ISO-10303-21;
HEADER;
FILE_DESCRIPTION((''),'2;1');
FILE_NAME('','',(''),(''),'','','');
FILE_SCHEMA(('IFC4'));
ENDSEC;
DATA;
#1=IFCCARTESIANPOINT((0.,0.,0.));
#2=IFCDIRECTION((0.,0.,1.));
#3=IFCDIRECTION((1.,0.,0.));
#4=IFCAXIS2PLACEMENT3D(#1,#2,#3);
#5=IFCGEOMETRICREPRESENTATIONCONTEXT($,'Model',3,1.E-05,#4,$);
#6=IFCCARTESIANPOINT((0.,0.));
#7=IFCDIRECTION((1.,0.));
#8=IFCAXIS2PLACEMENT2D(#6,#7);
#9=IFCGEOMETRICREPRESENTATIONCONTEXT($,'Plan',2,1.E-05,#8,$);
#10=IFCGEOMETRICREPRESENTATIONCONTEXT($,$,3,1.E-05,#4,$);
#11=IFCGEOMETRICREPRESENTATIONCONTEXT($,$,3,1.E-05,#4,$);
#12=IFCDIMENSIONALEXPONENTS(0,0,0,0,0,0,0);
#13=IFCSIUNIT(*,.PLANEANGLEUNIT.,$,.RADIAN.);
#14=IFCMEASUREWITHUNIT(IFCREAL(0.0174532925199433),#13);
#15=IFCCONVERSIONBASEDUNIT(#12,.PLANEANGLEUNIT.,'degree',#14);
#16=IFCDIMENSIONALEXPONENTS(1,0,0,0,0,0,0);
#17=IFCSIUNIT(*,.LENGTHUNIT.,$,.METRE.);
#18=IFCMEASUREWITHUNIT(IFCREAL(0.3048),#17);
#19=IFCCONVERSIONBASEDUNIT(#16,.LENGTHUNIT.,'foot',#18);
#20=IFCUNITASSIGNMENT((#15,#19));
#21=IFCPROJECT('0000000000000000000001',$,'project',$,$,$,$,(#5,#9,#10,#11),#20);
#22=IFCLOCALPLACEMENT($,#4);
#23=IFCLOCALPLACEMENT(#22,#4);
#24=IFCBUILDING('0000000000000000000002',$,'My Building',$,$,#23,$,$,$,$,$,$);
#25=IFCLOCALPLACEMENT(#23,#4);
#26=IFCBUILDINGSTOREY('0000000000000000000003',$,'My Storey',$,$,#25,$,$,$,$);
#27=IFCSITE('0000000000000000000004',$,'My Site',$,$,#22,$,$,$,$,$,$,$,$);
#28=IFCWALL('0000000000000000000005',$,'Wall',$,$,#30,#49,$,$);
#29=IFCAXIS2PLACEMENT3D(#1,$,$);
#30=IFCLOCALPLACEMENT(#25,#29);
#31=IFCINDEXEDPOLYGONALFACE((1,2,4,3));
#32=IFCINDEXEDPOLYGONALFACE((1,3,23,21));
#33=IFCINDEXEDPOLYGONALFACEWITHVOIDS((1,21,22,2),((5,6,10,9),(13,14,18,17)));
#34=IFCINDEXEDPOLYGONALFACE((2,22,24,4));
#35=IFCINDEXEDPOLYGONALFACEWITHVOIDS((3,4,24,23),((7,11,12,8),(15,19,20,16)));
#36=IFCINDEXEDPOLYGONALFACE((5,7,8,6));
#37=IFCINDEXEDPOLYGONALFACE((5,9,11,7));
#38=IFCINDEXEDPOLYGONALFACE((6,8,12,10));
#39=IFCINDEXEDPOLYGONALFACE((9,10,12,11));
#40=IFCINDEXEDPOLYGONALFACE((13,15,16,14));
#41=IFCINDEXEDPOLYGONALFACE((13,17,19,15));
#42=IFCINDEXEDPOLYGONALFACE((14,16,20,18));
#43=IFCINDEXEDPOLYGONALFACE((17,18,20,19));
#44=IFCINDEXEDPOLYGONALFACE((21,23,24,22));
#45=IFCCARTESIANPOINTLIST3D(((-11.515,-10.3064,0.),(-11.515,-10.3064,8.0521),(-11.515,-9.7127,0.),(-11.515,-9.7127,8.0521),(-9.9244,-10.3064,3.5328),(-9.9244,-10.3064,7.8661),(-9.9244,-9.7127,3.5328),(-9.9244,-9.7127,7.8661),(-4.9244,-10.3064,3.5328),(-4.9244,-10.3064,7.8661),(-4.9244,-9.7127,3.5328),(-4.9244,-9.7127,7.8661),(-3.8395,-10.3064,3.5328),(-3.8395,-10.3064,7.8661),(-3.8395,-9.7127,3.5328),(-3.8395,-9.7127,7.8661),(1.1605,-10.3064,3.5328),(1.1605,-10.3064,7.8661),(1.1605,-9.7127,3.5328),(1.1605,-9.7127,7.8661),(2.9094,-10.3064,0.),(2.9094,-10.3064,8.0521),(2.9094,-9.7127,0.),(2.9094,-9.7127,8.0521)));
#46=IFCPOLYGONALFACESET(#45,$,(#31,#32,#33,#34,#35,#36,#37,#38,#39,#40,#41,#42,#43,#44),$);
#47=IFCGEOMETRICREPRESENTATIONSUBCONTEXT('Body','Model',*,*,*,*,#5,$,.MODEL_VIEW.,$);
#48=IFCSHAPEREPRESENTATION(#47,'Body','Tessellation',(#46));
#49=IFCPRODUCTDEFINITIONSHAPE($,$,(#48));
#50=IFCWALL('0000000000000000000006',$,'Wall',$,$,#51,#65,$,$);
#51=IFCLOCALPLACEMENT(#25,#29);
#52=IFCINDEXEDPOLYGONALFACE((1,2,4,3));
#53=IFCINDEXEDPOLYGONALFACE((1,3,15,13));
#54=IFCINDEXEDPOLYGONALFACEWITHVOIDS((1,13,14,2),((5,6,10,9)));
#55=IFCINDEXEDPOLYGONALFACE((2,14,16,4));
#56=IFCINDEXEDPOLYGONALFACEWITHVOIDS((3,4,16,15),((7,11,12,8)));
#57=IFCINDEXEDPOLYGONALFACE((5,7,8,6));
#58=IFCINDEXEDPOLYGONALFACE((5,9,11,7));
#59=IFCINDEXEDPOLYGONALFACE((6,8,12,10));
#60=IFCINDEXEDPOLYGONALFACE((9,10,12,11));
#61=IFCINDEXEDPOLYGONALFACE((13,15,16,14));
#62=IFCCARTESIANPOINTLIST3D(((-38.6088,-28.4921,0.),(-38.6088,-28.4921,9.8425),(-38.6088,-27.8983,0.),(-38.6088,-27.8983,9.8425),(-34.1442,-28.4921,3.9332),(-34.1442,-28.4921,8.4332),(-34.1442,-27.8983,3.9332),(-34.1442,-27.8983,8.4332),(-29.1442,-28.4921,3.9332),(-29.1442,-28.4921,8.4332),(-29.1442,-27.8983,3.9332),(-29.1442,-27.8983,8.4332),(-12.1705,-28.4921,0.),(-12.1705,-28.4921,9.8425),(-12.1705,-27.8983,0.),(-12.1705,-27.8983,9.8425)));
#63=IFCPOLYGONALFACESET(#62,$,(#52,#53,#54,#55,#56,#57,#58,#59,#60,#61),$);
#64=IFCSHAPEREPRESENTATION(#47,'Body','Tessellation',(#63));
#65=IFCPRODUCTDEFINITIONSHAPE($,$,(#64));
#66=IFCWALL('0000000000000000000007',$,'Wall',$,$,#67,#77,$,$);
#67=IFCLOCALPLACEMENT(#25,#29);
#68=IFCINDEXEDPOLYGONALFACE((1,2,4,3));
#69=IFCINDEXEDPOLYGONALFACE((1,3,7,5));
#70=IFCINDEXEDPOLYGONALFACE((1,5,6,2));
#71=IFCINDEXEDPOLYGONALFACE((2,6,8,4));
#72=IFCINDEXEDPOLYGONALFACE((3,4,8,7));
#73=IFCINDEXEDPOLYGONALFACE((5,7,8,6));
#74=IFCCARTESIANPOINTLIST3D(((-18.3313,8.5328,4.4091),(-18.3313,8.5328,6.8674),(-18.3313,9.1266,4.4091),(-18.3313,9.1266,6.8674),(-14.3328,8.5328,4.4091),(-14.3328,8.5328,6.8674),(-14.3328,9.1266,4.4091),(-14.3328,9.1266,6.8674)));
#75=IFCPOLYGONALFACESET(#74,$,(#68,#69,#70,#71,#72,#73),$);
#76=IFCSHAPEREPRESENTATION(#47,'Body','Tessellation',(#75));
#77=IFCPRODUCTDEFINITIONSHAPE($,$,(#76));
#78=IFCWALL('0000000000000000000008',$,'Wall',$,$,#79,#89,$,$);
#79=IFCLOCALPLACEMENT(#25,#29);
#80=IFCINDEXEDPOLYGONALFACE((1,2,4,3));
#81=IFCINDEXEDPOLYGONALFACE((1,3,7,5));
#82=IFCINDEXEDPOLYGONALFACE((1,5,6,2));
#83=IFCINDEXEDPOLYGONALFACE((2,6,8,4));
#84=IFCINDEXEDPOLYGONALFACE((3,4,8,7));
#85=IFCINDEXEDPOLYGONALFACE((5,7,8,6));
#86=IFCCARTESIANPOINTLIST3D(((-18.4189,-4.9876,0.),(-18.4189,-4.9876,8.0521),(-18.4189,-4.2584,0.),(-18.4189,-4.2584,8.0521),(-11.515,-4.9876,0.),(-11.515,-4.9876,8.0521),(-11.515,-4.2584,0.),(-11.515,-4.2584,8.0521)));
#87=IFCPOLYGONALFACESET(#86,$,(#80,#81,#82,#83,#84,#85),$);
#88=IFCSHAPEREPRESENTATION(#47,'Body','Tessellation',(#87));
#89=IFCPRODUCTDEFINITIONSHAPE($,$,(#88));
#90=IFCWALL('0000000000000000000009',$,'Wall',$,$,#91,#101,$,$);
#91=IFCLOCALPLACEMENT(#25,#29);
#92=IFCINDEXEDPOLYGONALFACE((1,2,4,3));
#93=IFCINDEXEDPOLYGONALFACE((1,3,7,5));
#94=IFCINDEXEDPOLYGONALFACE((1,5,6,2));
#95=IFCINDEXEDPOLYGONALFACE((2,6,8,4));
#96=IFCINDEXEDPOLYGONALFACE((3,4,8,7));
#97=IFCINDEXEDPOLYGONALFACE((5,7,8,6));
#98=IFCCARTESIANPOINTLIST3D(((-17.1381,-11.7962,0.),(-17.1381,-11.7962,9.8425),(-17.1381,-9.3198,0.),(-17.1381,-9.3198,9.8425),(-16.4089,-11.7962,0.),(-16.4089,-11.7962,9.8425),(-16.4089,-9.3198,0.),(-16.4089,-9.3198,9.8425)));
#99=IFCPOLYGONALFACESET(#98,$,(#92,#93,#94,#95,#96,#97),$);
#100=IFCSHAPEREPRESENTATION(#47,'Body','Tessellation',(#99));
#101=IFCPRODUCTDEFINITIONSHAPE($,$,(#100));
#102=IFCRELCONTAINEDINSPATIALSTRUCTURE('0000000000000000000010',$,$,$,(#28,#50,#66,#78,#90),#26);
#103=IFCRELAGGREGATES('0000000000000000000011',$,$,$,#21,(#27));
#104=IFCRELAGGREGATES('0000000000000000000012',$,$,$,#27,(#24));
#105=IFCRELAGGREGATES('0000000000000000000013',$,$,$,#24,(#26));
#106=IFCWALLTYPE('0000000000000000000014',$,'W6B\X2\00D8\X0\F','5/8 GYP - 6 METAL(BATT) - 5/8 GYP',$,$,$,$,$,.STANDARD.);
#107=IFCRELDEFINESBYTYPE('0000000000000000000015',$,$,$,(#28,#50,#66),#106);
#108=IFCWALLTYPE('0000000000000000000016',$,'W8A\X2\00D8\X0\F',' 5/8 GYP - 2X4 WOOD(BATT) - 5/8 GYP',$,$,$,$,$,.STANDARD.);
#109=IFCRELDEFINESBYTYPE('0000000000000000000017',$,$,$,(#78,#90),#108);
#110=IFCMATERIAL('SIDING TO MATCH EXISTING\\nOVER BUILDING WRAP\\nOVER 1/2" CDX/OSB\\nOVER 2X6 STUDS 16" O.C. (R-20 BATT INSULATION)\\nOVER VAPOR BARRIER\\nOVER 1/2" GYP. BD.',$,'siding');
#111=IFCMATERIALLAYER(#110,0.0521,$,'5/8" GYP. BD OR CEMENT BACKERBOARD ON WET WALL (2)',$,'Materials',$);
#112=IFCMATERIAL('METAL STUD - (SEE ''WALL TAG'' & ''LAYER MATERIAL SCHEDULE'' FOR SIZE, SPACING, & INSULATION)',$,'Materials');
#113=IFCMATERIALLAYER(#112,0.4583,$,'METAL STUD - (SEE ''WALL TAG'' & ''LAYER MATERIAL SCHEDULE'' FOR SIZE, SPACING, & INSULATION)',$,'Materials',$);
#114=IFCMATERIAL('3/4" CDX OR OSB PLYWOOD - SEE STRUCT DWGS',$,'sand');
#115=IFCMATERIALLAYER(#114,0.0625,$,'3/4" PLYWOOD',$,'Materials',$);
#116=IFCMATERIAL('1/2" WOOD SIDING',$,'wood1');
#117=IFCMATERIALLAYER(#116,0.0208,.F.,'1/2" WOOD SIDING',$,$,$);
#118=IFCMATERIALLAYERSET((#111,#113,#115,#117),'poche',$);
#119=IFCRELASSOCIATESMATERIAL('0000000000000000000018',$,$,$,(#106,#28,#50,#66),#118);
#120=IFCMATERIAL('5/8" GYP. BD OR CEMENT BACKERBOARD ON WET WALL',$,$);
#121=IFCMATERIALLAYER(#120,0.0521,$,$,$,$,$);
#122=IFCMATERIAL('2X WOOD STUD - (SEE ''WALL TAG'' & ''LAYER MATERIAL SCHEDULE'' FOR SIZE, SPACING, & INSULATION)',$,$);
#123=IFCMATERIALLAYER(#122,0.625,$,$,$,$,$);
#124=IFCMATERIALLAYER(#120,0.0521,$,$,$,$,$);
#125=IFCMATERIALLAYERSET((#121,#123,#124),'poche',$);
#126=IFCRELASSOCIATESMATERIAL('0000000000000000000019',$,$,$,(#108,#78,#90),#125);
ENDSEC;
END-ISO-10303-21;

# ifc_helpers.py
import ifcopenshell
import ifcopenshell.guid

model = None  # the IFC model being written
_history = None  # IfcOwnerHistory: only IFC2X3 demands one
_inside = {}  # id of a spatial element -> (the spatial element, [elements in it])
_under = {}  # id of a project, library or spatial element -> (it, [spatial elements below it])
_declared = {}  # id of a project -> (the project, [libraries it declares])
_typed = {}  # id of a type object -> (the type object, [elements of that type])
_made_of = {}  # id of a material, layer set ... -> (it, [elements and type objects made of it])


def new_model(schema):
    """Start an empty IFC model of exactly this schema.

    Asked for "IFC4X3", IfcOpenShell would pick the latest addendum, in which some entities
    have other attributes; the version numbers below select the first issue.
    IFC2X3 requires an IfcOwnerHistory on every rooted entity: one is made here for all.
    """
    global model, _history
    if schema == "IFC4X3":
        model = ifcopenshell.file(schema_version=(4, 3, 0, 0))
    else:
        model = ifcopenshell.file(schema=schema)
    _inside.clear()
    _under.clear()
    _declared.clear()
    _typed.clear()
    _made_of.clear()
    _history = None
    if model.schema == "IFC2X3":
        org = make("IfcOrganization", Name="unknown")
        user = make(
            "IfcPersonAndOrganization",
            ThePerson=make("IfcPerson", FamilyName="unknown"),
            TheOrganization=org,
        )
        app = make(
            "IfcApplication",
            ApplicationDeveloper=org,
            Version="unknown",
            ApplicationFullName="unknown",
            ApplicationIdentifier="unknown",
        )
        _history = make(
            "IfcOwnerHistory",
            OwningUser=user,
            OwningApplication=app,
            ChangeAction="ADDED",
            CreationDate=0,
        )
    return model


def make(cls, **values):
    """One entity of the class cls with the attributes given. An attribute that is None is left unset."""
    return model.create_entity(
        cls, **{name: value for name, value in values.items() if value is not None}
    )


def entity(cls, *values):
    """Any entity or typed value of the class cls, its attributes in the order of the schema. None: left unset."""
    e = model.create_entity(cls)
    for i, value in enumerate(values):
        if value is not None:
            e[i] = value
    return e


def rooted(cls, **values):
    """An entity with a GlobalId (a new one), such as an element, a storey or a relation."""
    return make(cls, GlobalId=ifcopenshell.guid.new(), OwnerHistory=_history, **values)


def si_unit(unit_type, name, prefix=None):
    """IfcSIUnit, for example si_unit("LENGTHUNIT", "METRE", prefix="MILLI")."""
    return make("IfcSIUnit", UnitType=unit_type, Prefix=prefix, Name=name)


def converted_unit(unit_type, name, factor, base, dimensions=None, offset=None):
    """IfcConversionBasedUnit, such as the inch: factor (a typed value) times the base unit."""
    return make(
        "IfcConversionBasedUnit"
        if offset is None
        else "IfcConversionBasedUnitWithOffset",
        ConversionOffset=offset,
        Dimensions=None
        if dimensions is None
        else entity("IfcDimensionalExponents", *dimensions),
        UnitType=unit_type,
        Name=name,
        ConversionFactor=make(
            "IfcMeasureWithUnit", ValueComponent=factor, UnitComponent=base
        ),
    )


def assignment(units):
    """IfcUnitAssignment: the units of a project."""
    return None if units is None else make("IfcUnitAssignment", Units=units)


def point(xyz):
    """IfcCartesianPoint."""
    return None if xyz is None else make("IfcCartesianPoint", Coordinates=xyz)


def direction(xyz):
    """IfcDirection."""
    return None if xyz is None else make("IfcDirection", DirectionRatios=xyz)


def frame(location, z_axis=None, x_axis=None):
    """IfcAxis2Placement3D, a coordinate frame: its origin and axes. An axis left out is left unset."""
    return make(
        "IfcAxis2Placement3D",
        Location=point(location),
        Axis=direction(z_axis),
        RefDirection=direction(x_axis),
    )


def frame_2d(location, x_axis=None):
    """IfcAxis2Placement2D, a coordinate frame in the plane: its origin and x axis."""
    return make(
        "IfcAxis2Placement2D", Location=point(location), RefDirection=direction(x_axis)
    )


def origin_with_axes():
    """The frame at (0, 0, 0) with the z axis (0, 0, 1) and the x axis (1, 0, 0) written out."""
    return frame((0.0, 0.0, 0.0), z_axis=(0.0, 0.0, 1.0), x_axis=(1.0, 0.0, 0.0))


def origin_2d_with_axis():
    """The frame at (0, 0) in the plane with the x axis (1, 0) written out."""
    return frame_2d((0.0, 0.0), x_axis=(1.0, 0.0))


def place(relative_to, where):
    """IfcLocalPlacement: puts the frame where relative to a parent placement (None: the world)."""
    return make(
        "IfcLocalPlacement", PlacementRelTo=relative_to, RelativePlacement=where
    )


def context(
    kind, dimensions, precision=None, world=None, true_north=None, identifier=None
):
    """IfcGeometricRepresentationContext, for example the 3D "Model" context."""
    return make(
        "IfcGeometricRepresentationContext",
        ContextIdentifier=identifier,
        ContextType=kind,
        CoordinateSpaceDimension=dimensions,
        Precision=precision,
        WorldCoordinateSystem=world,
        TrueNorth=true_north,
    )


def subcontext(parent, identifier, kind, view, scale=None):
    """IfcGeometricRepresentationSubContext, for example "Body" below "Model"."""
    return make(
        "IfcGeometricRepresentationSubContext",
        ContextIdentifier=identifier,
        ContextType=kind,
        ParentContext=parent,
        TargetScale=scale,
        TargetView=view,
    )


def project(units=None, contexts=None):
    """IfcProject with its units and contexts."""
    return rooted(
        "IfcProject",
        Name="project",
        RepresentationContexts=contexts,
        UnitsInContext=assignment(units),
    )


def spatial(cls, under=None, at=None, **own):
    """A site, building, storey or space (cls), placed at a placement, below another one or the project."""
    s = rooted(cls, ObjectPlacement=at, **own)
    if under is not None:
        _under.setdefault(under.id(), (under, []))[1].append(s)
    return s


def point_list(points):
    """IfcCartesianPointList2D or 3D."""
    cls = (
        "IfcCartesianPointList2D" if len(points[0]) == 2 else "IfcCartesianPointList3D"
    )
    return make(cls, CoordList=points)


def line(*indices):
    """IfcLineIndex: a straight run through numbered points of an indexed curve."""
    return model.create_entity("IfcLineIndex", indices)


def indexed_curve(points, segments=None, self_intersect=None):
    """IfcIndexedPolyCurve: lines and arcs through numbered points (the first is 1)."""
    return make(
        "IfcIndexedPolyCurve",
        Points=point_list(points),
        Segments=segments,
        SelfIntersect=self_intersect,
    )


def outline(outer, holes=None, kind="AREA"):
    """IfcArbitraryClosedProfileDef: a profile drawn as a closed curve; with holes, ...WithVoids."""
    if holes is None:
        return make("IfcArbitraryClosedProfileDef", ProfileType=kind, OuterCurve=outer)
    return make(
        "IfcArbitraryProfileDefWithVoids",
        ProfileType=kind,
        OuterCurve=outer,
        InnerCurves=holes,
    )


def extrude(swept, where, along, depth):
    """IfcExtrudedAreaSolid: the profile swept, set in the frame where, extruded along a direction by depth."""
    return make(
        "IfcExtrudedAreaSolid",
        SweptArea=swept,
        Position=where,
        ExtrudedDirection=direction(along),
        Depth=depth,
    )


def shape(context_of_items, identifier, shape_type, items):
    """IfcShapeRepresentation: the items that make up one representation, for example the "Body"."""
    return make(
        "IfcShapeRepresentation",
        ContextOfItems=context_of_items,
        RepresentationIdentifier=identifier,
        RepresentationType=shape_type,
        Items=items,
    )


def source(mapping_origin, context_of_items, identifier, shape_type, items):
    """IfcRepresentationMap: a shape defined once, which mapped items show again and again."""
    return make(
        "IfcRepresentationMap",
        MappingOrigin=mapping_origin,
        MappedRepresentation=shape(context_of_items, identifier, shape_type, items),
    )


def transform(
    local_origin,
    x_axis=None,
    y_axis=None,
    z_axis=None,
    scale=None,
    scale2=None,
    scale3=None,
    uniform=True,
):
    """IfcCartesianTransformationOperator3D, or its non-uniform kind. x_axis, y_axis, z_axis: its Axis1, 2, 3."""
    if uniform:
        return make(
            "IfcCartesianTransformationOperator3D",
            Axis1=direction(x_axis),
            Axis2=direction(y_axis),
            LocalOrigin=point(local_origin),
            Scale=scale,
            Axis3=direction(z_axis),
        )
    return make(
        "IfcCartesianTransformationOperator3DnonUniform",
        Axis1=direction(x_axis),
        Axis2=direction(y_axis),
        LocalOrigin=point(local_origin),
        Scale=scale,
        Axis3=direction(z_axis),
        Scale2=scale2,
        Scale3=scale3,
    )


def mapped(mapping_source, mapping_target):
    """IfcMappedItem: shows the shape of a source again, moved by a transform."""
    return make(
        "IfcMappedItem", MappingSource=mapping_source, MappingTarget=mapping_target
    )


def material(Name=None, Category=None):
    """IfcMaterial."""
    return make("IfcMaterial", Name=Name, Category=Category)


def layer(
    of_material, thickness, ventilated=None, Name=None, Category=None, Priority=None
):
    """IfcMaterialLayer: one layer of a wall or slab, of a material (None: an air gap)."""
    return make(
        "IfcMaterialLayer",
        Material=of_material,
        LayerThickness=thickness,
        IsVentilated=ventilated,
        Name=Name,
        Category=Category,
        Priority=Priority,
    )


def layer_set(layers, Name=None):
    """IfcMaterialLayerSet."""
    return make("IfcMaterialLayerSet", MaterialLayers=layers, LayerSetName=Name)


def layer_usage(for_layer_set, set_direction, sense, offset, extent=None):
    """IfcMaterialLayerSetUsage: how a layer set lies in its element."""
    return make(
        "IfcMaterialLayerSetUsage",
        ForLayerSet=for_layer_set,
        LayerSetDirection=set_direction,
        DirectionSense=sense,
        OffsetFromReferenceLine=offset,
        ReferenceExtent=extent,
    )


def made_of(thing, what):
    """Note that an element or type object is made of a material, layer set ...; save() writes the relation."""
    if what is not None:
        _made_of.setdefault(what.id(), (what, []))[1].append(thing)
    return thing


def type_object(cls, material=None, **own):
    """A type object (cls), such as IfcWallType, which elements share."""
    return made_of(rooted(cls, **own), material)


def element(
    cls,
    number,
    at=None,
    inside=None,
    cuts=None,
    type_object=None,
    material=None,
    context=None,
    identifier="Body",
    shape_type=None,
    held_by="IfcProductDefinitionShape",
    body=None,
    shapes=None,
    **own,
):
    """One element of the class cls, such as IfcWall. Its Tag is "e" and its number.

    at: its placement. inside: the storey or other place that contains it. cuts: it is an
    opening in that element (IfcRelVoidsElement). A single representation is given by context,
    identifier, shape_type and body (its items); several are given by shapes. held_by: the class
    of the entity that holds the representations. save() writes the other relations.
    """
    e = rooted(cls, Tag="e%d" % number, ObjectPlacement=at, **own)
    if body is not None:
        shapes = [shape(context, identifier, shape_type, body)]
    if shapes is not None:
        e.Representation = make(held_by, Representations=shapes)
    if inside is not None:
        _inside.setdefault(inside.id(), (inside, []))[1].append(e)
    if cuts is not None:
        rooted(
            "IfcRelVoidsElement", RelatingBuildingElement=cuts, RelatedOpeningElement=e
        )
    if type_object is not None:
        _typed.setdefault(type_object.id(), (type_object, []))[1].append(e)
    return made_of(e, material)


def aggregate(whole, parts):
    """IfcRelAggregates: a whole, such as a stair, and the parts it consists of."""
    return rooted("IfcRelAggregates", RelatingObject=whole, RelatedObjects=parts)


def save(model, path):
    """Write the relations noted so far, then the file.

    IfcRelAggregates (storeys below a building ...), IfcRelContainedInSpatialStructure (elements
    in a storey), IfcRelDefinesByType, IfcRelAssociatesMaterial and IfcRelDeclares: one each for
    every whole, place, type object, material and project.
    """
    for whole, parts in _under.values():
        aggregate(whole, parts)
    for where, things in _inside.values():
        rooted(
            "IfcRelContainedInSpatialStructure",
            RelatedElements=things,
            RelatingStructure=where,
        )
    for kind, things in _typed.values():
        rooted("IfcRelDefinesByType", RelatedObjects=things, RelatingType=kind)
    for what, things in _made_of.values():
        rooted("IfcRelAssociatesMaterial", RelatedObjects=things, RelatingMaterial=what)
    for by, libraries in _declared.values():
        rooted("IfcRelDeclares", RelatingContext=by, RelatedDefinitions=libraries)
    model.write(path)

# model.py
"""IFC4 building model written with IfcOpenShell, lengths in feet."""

from ifc_helpers import new_model, entity, si_unit, converted_unit, frame, origin_with_axes, origin_2d_with_axis, place, context, subcontext, project, spatial, line, indexed_curve, outline, extrude, source, transform, mapped, material, layer, layer_set, layer_usage, type_object, element, save


model = new_model("IFC4")

# Units and contexts
model_context = context("Model", 3, precision=1e-05, world=origin_with_axes())
plan_context = context("Plan", 2, precision=1e-05, world=origin_2d_with_axis())
context_of_model_1 = context(None, 3, precision=1e-05, world=origin_with_axes())
context_of_model_2 = context(None, 3, precision=1e-05, world=origin_with_axes())
body_context = subcontext(model_context, "Body", "Model", "MODEL_VIEW")
ifc_project = project(units=[converted_unit("PLANEANGLEUNIT", "degree", entity("IfcReal", 0.0174532925199433), si_unit("PLANEANGLEUNIT", "RADIAN"), dimensions=[0, 0, 0, 0, 0, 0, 0]), converted_unit("LENGTHUNIT", "foot", entity("IfcReal", 0.3048), si_unit("LENGTHUNIT", "METRE"), dimensions=[1, 0, 0, 0, 0, 0, 0])], contexts=[model_context, plan_context, context_of_model_1, context_of_model_2])

# Site, building, storey
site_placement = place(None, origin_with_axes())
site = spatial("IfcSite", under=ifc_project, at=site_placement, Name="My Site")
building_placement = place(site_placement, origin_with_axes())
building = spatial("IfcBuilding", under=site, at=building_placement, Name="My Building")
storey_placement = place(building_placement, origin_with_axes())
storey = spatial("IfcBuildingStorey", under=building, at=storey_placement, Name="My Storey")

# Shared definitions
ifc_material_1 = material(Name="5/8\" GYP. BD OR CEMENT BACKERBOARD ON WET WALL")
ifc_material_2 = material(Name="2X WOOD STUD - (SEE 'WALL TAG' & 'LAYER MATERIAL SCHEDULE' FOR SIZE, SPACING, & INSULATION)")
ifc_material_3 = material(Name="SIDING TO MATCH EXISTING\\nOVER BUILDING WRAP\\nOVER 1/2\" CDX/OSB\\nOVER 2X6 STUDS 16\" O.C. (R-20 BATT INSULATION)\\nOVER VAPOR BARRIER\\nOVER 1/2\" GYP. BD.", Category="siding")
ifc_layer_1 = layer(ifc_material_3, 0.0521, Name="5/8\" GYP. BD OR CEMENT BACKERBOARD ON WET WALL (2)", Category="Materials")
ifc_material_4 = material(Name="METAL STUD - (SEE 'WALL TAG' & 'LAYER MATERIAL SCHEDULE' FOR SIZE, SPACING, & INSULATION)", Category="Materials")
ifc_layer_2 = layer(ifc_material_4, 0.4583, Name="METAL STUD - (SEE 'WALL TAG' & 'LAYER MATERIAL SCHEDULE' FOR SIZE, SPACING, & INSULATION)", Category="Materials")
ifc_material_5 = material(Name="3/4\" CDX OR OSB PLYWOOD - SEE STRUCT DWGS", Category="sand")
ifc_layer_3 = layer(ifc_material_5, 0.0625, Name="3/4\" PLYWOOD", Category="Materials")
ifc_material_6 = material(Name="1/2\" WOOD SIDING", Category="wood1")
ifc_layer_4 = layer(ifc_material_6, 0.0208, ventilated=False, Name="1/2\" WOOD SIDING")
ifc_layer_set_1 = layer_set([ifc_layer_1, ifc_layer_2, ifc_layer_3, ifc_layer_4], Name="poche")
wall_type_1 = type_object("IfcWallType", Name="W6BØF", Description="5/8 GYP - 6 METAL(BATT) - 5/8 GYP", PredefinedType="STANDARD", material=ifc_layer_set_1)

# Wall, openings
ifc_layer_usage_1 = layer_usage(ifc_layer_set_1, "AXIS2", "POSITIVE", 0.0)
wall_1_placement = place(storey_placement, frame((-11.515, -10.3064, 0.0), z_axis=(0.0, 0.0, 1.0), x_axis=(1.0, 0.0, 0.0)))
wall_1 = element("IfcWall", 1, at=wall_1_placement, inside=storey, type_object=wall_type_1, material=ifc_layer_usage_1, Name="Wall", context=body_context, shape_type="SweptSolid", body=[
    extrude(outline(indexed_curve([(0.0, 0.0), (0.0, 0.5937), (14.4243, 0.5937), (14.4243, 0.0), (0.0, 0.0)], self_intersect=False)), origin_with_axes(), (0.0, 0.0, 1.0), 8.0521),
])
shared_shape_1 = source(origin_with_axes(), body_context, "Body", "SweptSolid", [
    extrude(outline(indexed_curve([(0.0, 0.0), (5.0, 0.0), (5.0, 4.3333), (0.0, 4.3333)], segments=[line(1, 2, 3, 4, 1)])), frame((0.0, -1.9685, 0.0), z_axis=(0.0, -1.0, 0.0), x_axis=(1.0, 0.0, 0.0)), (0.0, 0.0, -1.0), 3.937),
])
opening_1_placement = place(wall_1_placement, frame((1.5905, 0.0, 3.5328), z_axis=(0.0, 0.0, 1.0), x_axis=(1.0, 0.0, 0.0)))
element("IfcOpeningElement", 2, at=opening_1_placement, cuts=wall_1, PredefinedType="OPENING", context=body_context, shape_type="MappedRepresentation", body=[
    mapped(shared_shape_1, transform((0.0, 0.0, 0.0), x_axis=(1.0, 0.0, 0.0), y_axis=(0.0, 1.0, 0.0), z_axis=(0.0, 0.0, 1.0), scale=1.0)),
])
opening_2_placement = place(wall_1_placement, frame((7.6755, 0.0, 3.5328), z_axis=(0.0, 0.0, 1.0), x_axis=(1.0, 0.0, 0.0)))
element("IfcOpeningElement", 3, at=opening_2_placement, cuts=wall_1, PredefinedType="OPENING", context=body_context, shape_type="MappedRepresentation", body=[
    mapped(shared_shape_1, transform((0.0, 0.0, 0.0), x_axis=(1.0, 0.0, 0.0), y_axis=(0.0, 1.0, 0.0), z_axis=(0.0, 0.0, 1.0), scale=1.0)),
])

# Wall, opening
ifc_layer_usage_2 = layer_usage(ifc_layer_set_1, "AXIS2", "POSITIVE", 0.0)
wall_2_placement = place(storey_placement, frame((-12.1705, -27.8983, 0.0), z_axis=(0.0, 0.0, 1.0), x_axis=(-1.0, 0.0, 0.0)))
wall_2 = element("IfcWall", 4, at=wall_2_placement, inside=storey, type_object=wall_type_1, material=ifc_layer_usage_2, Name="Wall", context=body_context, shape_type="SweptSolid", body=[
    extrude(outline(indexed_curve([(0.0, 0.0), (0.0, 0.5937), (26.4383, 0.5937), (26.4383, 0.0), (0.0, 0.0)], self_intersect=False)), origin_with_axes(), (0.0, 0.0, 1.0), 9.8425),
])
shared_shape_2 = source(origin_with_axes(), body_context, "Body", "SweptSolid", [
    extrude(outline(indexed_curve([(0.0, 0.0), (5.0, 0.0), (5.0, 4.5), (0.0, 4.5)], segments=[line(1, 2, 3, 4, 1)])), frame((0.0, -1.9685, 0.0), z_axis=(0.0, -1.0, 0.0), x_axis=(1.0, 0.0, 0.0)), (0.0, 0.0, -1.0), 3.937),
])
opening_3_placement = place(wall_2_placement, frame((16.9736, 0.0, 3.9332), z_axis=(0.0, 0.0, 1.0), x_axis=(1.0, 0.0, 0.0)))
element("IfcOpeningElement", 5, at=opening_3_placement, cuts=wall_2, PredefinedType="OPENING", context=body_context, shape_type="MappedRepresentation", body=[
    mapped(shared_shape_2, transform((0.0, 0.0, 0.0), x_axis=(1.0, 0.0, 0.0), y_axis=(0.0, 1.0, 0.0), z_axis=(0.0, 0.0, 1.0), scale=1.0)),
])

# Walls
ifc_layer_usage_3 = layer_usage(ifc_layer_set_1, "AXIS2", "POSITIVE", 0.0)
wall_3_placement = place(storey_placement, frame((-18.3313, 8.5328, 4.4091), z_axis=(0.0, 0.0, 1.0), x_axis=(1.0, 0.0, 0.0)))
element("IfcWall", 6, at=wall_3_placement, inside=storey, type_object=wall_type_1, material=ifc_layer_usage_3, Name="Wall", context=body_context, shape_type="SweptSolid", body=[
    extrude(outline(indexed_curve([(0.0, 0.0), (0.0, 0.5937), (3.9985, 0.5937), (3.9985, 0.0), (0.0, 0.0)], self_intersect=False)), origin_with_axes(), (0.0, 0.0, 1.0), 2.4583),
])
ifc_layer_5 = layer(ifc_material_1, 0.0521)
ifc_layer_6 = layer(ifc_material_2, 0.625)
ifc_layer_7 = layer(ifc_material_1, 0.0521)
ifc_layer_set_2 = layer_set([ifc_layer_5, ifc_layer_6, ifc_layer_7], Name="poche")
ifc_layer_usage_4 = layer_usage(ifc_layer_set_2, "AXIS2", "POSITIVE", 0.0)
wall_type_2 = type_object("IfcWallType", Name="W8AØF", Description=" 5/8 GYP - 2X4 WOOD(BATT) - 5/8 GYP", PredefinedType="STANDARD", material=ifc_layer_set_2)
wall_4_placement = place(storey_placement, frame((-18.4189, -4.9876, 0.0), z_axis=(0.0, 0.0, 1.0), x_axis=(1.0, 0.0, 0.0)))
element("IfcWall", 7, at=wall_4_placement, inside=storey, type_object=wall_type_2, material=ifc_layer_usage_4, Name="Wall", context=body_context, shape_type="SweptSolid", body=[
    extrude(outline(indexed_curve([(0.0, 0.0), (0.0, 0.7292), (6.9039, 0.7292), (6.9039, 0.0), (0.0, 0.0)], self_intersect=False)), origin_with_axes(), (0.0, 0.0, 1.0), 8.0521),
])
ifc_layer_usage_5 = layer_usage(ifc_layer_set_2, "AXIS2", "POSITIVE", 0.0)
wall_5_placement = place(storey_placement, frame((-16.4089, -11.7962, 0.0), z_axis=(0.0, 0.0, 1.0), x_axis=(0.0, 1.0, 0.0)))
element("IfcWall", 8, at=wall_5_placement, inside=storey, type_object=wall_type_2, material=ifc_layer_usage_5, Name="Wall", context=body_context, shape_type="SweptSolid", body=[
    extrude(outline(indexed_curve([(0.0, 0.0), (0.0, 0.7292), (2.4764, 0.7292), (2.4764, 0.0), (0.0, 0.0)], self_intersect=False)), origin_with_axes(), (0.0, 0.0, 1.0), 9.8425),
])

save(model, "model.ifc")
